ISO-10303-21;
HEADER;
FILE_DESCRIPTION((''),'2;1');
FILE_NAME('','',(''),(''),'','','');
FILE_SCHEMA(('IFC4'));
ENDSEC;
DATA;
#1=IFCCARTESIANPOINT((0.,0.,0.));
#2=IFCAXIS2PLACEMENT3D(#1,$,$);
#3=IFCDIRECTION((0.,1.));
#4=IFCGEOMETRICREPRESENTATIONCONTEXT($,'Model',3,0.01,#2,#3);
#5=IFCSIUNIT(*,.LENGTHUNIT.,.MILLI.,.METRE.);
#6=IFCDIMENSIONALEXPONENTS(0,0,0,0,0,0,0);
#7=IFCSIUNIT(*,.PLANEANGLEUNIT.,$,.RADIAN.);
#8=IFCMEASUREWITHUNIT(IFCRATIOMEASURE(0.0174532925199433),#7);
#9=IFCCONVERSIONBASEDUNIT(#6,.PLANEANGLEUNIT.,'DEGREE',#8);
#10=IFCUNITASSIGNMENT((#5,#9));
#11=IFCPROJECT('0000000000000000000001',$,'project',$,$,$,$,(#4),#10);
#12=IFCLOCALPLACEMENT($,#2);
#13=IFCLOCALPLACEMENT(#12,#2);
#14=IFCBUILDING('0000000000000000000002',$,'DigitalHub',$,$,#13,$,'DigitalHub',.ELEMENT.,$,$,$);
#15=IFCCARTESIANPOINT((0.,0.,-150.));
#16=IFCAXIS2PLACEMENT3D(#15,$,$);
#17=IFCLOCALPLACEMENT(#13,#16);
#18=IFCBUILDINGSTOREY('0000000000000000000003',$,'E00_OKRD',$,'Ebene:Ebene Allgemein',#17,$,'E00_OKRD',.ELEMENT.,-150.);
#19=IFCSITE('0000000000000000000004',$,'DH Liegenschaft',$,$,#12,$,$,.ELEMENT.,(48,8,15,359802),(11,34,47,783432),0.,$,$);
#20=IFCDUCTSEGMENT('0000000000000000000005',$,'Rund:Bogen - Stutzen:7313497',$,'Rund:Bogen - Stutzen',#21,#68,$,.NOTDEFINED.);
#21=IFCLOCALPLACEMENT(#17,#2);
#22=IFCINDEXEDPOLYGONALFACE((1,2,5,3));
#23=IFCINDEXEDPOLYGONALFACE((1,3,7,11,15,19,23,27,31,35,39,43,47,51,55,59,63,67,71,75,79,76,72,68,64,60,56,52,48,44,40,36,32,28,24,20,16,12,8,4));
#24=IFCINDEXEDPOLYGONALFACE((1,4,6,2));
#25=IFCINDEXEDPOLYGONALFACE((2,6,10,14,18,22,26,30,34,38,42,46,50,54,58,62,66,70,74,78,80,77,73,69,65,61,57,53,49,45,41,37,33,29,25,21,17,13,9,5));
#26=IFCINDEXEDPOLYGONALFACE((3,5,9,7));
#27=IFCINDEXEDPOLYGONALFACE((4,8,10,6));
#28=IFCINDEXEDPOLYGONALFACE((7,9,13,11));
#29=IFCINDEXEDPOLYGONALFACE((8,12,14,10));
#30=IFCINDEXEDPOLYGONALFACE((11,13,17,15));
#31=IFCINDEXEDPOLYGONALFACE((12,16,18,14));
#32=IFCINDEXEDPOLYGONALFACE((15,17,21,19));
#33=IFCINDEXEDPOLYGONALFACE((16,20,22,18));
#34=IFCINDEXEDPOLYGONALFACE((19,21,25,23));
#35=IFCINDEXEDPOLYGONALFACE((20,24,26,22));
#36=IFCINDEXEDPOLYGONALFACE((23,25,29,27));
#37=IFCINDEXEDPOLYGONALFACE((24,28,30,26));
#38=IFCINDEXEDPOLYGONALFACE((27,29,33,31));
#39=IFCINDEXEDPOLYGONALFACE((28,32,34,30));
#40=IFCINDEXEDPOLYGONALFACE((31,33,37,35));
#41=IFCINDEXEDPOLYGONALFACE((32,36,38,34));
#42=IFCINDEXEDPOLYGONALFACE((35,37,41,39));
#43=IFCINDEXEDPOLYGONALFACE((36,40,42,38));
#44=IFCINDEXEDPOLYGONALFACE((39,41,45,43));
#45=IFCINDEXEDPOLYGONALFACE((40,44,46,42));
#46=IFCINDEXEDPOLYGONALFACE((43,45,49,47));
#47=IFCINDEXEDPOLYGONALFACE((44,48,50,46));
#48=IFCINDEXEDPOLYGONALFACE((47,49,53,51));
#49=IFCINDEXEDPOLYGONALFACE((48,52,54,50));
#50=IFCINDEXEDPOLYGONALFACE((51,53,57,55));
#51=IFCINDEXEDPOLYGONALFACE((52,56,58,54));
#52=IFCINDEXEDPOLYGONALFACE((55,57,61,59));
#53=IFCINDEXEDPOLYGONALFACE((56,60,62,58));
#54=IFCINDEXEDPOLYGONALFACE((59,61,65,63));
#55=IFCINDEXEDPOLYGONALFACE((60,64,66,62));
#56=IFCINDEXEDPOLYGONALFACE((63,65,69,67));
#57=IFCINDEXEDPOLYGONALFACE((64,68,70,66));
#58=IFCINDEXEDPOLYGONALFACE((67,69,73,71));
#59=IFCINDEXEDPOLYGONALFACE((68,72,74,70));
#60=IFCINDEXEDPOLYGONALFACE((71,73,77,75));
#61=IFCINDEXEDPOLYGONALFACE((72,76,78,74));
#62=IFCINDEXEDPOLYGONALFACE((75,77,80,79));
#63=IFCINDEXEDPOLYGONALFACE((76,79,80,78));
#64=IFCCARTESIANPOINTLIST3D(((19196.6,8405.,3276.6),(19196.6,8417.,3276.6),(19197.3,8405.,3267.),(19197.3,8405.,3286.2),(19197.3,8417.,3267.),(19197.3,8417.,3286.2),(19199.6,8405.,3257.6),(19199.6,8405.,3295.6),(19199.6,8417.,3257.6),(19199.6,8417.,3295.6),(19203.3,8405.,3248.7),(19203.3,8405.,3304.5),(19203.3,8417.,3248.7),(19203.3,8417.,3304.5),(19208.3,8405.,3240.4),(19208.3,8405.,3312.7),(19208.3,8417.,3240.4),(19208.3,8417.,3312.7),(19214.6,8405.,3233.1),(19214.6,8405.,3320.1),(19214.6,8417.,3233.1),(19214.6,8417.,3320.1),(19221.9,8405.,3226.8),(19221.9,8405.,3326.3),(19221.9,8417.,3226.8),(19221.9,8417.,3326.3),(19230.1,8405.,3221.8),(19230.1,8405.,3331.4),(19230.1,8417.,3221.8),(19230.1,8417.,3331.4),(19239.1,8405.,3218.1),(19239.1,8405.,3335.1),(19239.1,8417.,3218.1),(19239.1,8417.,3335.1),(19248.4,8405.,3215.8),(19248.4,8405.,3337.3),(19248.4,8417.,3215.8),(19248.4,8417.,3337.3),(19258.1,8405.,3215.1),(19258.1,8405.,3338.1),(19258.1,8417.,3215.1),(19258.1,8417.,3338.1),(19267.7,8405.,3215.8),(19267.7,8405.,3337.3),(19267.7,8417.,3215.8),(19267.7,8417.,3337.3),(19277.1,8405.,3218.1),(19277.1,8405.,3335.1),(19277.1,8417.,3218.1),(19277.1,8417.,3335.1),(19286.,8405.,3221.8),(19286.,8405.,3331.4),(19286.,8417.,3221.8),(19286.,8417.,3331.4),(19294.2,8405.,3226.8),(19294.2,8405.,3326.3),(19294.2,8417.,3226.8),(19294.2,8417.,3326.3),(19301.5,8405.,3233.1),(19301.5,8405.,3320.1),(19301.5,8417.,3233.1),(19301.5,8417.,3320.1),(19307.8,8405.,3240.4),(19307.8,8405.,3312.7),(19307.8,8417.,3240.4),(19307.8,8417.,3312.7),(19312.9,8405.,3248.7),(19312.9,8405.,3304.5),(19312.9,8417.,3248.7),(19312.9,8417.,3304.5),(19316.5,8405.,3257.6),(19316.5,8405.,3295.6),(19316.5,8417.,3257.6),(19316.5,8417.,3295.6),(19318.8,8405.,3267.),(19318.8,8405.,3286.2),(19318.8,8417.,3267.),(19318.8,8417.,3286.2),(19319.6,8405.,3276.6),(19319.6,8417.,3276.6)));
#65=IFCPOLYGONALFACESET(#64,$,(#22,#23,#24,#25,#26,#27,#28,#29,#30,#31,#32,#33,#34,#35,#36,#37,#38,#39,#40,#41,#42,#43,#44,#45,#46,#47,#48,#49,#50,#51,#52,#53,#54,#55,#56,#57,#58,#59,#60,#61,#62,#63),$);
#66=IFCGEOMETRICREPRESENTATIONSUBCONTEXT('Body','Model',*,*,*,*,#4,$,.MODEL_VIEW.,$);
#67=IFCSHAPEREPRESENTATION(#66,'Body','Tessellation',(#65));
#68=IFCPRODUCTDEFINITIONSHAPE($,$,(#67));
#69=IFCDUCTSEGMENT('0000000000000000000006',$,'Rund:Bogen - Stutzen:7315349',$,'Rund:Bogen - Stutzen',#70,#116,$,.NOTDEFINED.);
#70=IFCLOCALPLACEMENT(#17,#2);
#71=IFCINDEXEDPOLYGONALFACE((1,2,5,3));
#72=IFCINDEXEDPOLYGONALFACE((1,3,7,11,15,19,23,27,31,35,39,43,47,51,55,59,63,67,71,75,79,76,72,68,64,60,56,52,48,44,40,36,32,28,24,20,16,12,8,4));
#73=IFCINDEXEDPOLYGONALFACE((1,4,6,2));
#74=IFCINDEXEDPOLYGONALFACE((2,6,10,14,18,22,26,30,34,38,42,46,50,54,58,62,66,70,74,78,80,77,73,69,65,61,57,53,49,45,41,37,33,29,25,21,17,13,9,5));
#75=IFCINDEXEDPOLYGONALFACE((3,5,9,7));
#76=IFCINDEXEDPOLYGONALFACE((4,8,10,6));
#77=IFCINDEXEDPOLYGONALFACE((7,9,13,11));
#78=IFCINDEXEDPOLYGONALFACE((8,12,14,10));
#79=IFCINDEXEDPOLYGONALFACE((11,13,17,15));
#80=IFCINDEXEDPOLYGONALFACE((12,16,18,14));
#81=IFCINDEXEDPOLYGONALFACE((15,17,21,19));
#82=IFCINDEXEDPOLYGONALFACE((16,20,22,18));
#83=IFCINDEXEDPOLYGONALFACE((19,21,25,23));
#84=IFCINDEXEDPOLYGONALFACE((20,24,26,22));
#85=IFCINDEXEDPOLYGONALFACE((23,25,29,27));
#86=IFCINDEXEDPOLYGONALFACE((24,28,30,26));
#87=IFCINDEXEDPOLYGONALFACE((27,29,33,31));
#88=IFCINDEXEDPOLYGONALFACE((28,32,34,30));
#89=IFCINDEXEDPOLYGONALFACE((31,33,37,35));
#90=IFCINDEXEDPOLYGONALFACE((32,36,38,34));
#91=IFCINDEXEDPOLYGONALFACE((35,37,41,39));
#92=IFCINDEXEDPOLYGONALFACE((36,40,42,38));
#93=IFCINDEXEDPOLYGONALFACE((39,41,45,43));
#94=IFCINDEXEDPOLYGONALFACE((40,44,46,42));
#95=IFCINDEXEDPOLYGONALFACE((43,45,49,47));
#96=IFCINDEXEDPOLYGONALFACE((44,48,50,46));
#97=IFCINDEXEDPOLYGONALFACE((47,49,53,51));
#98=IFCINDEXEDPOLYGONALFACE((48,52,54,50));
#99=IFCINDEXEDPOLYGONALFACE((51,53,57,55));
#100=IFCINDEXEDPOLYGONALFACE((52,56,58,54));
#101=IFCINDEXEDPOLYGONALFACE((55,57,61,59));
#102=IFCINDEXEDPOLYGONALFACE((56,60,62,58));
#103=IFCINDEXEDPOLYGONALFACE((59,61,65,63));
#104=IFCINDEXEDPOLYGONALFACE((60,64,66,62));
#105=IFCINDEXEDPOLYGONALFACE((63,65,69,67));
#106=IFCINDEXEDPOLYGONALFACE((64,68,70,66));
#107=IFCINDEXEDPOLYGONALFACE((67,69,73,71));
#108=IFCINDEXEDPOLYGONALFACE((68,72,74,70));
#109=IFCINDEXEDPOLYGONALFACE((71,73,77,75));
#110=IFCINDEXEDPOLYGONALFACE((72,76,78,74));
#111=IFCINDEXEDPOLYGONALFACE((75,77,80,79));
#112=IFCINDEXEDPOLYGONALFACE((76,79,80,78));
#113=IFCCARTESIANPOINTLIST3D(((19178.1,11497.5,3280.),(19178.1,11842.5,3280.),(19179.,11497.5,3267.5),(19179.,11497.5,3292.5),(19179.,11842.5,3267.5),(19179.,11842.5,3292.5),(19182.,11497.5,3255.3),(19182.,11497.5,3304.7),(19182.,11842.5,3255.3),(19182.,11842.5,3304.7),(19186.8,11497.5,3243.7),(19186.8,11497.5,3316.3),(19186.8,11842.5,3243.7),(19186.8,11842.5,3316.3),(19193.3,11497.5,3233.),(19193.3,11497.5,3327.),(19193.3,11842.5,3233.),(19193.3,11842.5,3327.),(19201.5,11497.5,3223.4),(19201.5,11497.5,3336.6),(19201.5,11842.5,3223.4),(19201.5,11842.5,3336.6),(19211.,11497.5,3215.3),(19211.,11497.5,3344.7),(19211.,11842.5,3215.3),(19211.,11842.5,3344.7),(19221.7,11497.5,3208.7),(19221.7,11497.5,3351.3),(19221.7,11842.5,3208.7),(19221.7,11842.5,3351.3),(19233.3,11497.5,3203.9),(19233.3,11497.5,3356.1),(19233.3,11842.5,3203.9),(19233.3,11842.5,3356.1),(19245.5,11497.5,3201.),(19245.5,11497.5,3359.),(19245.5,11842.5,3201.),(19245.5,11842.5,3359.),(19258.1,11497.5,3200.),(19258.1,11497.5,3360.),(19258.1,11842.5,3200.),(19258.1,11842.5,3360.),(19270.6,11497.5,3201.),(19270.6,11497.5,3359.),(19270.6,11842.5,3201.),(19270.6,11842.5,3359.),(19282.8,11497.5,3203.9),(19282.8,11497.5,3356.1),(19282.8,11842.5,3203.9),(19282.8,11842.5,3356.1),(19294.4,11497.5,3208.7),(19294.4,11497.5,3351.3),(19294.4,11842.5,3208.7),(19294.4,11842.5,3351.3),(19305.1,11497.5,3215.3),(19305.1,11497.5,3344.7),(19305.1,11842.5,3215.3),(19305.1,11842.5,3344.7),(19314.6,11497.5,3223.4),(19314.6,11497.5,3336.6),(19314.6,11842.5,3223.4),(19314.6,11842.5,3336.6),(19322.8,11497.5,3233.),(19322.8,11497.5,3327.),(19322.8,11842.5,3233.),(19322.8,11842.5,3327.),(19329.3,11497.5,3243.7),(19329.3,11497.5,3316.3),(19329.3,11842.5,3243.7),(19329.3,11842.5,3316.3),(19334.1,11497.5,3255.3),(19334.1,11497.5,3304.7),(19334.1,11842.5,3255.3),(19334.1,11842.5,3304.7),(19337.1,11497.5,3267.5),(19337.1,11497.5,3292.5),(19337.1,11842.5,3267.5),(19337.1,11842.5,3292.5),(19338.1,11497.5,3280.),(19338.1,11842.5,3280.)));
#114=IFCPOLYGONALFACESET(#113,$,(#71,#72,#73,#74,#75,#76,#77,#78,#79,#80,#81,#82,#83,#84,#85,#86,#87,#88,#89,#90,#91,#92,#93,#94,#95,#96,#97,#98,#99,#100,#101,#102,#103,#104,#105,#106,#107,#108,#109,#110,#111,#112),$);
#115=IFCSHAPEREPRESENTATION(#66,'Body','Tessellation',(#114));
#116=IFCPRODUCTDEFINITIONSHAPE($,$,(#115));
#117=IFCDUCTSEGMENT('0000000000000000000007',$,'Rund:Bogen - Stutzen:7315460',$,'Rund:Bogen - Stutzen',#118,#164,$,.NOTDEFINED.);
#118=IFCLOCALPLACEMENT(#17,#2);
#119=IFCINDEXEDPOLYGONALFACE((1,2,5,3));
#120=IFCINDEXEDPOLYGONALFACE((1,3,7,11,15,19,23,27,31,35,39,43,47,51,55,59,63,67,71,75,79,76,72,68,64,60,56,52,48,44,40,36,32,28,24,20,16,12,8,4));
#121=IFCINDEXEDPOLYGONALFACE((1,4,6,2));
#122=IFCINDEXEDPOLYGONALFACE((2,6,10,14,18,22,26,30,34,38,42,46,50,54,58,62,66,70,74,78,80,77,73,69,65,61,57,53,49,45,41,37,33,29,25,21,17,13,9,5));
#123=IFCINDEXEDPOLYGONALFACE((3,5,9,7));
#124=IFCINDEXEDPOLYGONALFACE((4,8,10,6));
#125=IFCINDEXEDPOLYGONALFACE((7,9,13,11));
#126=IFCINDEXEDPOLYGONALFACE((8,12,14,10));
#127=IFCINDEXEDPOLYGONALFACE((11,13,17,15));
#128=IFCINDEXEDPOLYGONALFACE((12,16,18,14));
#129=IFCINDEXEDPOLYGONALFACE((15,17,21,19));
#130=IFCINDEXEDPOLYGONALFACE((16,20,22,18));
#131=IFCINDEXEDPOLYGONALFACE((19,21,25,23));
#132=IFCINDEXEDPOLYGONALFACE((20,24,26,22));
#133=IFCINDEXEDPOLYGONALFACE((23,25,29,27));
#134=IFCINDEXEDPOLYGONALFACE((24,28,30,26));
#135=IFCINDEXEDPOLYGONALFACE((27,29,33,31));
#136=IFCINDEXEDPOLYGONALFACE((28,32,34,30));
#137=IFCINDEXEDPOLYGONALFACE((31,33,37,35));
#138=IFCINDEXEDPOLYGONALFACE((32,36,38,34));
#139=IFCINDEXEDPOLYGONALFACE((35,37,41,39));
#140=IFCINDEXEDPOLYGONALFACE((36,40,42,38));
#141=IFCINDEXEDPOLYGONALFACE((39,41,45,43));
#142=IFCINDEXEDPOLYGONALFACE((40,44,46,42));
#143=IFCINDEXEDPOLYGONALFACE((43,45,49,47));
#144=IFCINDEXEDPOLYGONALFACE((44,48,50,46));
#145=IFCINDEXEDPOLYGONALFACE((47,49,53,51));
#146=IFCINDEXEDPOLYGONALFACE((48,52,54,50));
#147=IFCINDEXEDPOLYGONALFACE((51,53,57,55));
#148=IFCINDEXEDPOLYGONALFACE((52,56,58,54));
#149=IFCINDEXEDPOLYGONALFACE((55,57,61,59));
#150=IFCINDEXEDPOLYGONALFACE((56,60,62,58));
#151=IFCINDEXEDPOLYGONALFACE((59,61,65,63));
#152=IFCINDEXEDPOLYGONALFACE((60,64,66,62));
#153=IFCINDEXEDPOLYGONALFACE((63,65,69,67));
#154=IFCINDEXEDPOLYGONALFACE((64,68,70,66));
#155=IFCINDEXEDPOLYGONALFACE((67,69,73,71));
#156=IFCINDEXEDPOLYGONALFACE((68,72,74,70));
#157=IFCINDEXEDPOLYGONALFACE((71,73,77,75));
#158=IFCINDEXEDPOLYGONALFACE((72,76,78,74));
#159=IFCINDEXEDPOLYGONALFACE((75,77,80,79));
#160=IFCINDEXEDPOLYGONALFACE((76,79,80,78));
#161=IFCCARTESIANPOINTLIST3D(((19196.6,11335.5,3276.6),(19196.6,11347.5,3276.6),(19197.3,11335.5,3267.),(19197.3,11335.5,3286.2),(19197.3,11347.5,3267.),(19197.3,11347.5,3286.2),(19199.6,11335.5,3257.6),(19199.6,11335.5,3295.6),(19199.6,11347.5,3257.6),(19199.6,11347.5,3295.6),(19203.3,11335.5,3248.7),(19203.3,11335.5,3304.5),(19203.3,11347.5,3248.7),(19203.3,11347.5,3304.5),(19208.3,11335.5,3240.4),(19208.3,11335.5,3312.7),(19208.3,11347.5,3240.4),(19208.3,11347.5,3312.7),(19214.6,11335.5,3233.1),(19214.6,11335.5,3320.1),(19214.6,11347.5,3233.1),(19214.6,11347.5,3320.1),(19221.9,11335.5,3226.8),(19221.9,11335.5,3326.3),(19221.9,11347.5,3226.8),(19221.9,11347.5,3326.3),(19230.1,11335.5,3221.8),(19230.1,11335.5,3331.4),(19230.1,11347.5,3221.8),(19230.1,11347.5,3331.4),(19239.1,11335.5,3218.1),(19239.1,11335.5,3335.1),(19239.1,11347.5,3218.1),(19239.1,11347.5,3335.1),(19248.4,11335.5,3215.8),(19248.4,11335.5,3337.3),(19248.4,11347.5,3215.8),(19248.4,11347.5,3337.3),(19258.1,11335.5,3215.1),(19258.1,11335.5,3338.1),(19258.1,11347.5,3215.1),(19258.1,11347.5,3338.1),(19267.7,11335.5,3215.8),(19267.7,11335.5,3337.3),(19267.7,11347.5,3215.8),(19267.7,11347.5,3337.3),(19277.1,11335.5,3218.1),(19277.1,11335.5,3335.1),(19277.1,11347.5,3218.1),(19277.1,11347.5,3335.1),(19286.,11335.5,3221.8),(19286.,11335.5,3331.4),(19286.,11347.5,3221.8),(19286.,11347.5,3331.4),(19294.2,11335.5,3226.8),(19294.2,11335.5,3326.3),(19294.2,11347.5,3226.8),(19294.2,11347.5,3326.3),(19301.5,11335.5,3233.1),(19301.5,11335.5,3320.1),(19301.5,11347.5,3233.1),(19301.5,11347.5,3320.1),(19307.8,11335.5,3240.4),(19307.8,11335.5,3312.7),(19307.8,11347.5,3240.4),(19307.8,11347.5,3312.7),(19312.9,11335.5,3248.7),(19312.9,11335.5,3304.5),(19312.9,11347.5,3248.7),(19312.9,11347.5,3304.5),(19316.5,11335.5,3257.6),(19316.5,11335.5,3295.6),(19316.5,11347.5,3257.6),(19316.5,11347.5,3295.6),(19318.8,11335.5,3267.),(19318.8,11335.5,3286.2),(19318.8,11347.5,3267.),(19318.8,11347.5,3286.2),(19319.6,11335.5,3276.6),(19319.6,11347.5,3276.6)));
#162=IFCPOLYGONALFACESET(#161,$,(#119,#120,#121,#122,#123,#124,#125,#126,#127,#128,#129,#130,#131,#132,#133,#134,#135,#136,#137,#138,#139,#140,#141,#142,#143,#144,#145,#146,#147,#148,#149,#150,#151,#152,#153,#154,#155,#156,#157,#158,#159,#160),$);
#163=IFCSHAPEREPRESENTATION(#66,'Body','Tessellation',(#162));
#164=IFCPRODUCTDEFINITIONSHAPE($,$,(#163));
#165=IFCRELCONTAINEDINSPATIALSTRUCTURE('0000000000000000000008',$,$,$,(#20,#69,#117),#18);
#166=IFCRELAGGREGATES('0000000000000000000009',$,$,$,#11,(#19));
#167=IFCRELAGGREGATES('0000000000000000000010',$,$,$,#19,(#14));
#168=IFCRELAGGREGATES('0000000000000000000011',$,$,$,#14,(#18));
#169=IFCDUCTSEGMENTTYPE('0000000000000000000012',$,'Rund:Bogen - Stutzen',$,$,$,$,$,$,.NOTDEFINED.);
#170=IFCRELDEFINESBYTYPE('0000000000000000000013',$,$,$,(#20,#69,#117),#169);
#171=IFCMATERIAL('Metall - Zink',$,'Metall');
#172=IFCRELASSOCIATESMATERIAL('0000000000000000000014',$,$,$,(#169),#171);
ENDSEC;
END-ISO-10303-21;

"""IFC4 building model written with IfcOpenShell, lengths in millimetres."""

from ifc_helpers import new_model, entity, si_unit, converted_unit, direction, frame, origin, place, context, subcontext, project, spatial, indexed_curve, outline, extrude, material, type_object, element, save


model = new_model("IFC4")

# Units and contexts
model_context = context("Model", 3, precision=0.01, world=origin(), true_north=direction((0.0, 1.0)))
body_context = subcontext(model_context, "Body", "Model", "MODEL_VIEW")
ifc_project = project(units=[si_unit("LENGTHUNIT", "METRE", prefix="MILLI"), converted_unit("PLANEANGLEUNIT", "DEGREE", entity("IfcRatioMeasure", 0.0174532925199433), si_unit("PLANEANGLEUNIT", "RADIAN"), dimensions=[0, 0, 0, 0, 0, 0, 0])], contexts=[model_context])

# Site, building, storey
site_placement = place(None, origin())
site = spatial("IfcSite", under=ifc_project, at=site_placement, Name="DH Liegenschaft", CompositionType="ELEMENT", RefLatitude=(48, 8, 15, 359802), RefLongitude=(11, 34, 47, 783432), RefElevation=0.0)
building_placement = place(site_placement, origin())
building = spatial("IfcBuilding", under=site, at=building_placement, Name="DigitalHub", LongName="DigitalHub", CompositionType="ELEMENT")
storey_placement = place(building_placement, frame((0.0, 0.0, -150.0)))
storey = spatial("IfcBuildingStorey", under=building, at=storey_placement, Name="E00_OKRD", ObjectType="Ebene:Ebene Allgemein", LongName="E00_OKRD", CompositionType="ELEMENT", Elevation=-150.0)

# Duct segments
ifc_material_1 = material(Name="Metall - Zink", Category="Metall")
duct_segment_type_1 = type_object("IfcDuctSegmentType", Name="Rund:Bogen - Stutzen", PredefinedType="NOTDEFINED", material=ifc_material_1)
duct_segment_1_placement = place(storey_placement, frame((19195.0, 8405.0, 3213.5)))
element("IfcDuctSegment", 1, at=duct_segment_1_placement, inside=storey, type_object=duct_segment_type_1, Name="Rund:Bogen - Stutzen:7313497", ObjectType="Rund:Bogen - Stutzen", PredefinedType="NOTDEFINED", context=body_context, shape_type="SweptSolid", body=[
    extrude(outline(indexed_curve([(61.5, 0.0), (60.7, 9.6), (58.5, 19.0), (54.8, 27.9), (49.8, 36.1), (43.5, 43.5), (36.1, 49.8), (27.9, 54.8), (19.0, 58.5), (9.6, 60.7), (0.0, 61.5), (-9.6, 60.7), (-19.0, 58.5), (-27.9, 54.8), (-36.1, 49.8), (-43.5, 43.5), (-49.8, 36.1), (-54.8, 27.9), (-58.5, 19.0), (-60.7, 9.6), (-61.5, 0.0), (-60.7, -9.6), (-58.5, -19.0), (-54.8, -27.9), (-49.8, -36.1), (-43.5, -43.5), (-36.1, -49.8), (-27.9, -54.8), (-19.0, -58.5), (-9.6, -60.7), (0.0, -61.5), (9.6, -60.7), (19.0, -58.5), (27.9, -54.8), (36.1, -49.8), (43.5, -43.5), (49.8, -36.1), (54.8, -27.9), (58.5, -19.0), (60.7, -9.6), (61.5, 0.0)], self_intersect=False)), frame((63.1, 0.0, 63.1), z_axis=(0.0, 1.0, 0.0), x_axis=(1.0, 0.0, 0.0)), (0.0, 0.0, 1.0), 12.0),
])
duct_segment_2_placement = place(storey_placement, frame((19176.5, 11497.5, 3198.4)))
element("IfcDuctSegment", 2, at=duct_segment_2_placement, inside=storey, type_object=duct_segment_type_1, Name="Rund:Bogen - Stutzen:7315349", ObjectType="Rund:Bogen - Stutzen", PredefinedType="NOTDEFINED", context=body_context, shape_type="SweptSolid", body=[
    extrude(outline(indexed_curve([(80.0, 0.0), (79.0, 12.5), (76.1, 24.7), (71.3, 36.3), (64.7, 47.0), (56.6, 56.6), (47.0, 64.7), (36.3, 71.3), (24.7, 76.1), (12.5, 79.0), (0.0, 80.0), (-12.5, 79.0), (-24.7, 76.1), (-36.3, 71.3), (-47.0, 64.7), (-56.6, 56.6), (-64.7, 47.0), (-71.3, 36.3), (-76.1, 24.7), (-79.0, 12.5), (-80.0, 0.0), (-79.0, -12.5), (-76.1, -24.7), (-71.3, -36.3), (-64.7, -47.0), (-56.6, -56.6), (-47.0, -64.7), (-36.3, -71.3), (-24.7, -76.1), (-12.5, -79.0), (0.0, -80.0), (12.5, -79.0), (24.7, -76.1), (36.3, -71.3), (47.0, -64.7), (56.6, -56.6), (64.7, -47.0), (71.3, -36.3), (76.1, -24.7), (79.0, -12.5), (80.0, 0.0)], self_intersect=False)), frame((81.6, 0.0, 81.6), z_axis=(0.0, 1.0, 0.0), x_axis=(-1.0, 0.0, 0.0)), (0.0, 0.0, 1.0), 345.0),
])
duct_segment_3_placement = place(storey_placement, frame((19195.0, 11335.5, 3213.5)))
element("IfcDuctSegment", 3, at=duct_segment_3_placement, inside=storey, type_object=duct_segment_type_1, Name="Rund:Bogen - Stutzen:7315460", ObjectType="Rund:Bogen - Stutzen", PredefinedType="NOTDEFINED", context=body_context, shape_type="SweptSolid", body=[
    extrude(outline(indexed_curve([(61.5, 0.0), (60.7, 9.6), (58.5, 19.0), (54.8, 27.9), (49.8, 36.1), (43.5, 43.5), (36.1, 49.8), (27.9, 54.8), (19.0, 58.5), (9.6, 60.7), (0.0, 61.5), (-9.6, 60.7), (-19.0, 58.5), (-27.9, 54.8), (-36.1, 49.8), (-43.5, 43.5), (-49.8, 36.1), (-54.8, 27.9), (-58.5, 19.0), (-60.7, 9.6), (-61.5, 0.0), (-60.7, -9.6), (-58.5, -19.0), (-54.8, -27.9), (-49.8, -36.1), (-43.5, -43.5), (-36.1, -49.8), (-27.9, -54.8), (-19.0, -58.5), (-9.6, -60.7), (0.0, -61.5), (9.6, -60.7), (19.0, -58.5), (27.9, -54.8), (36.1, -49.8), (43.5, -43.5), (49.8, -36.1), (54.8, -27.9), (58.5, -19.0), (60.7, -9.6), (61.5, 0.0)], self_intersect=False)), frame((63.1, 0.0, 63.1), z_axis=(0.0, 1.0, 0.0), x_axis=(-1.0, 0.0, 0.0)), (0.0, 0.0, 1.0), 12.0),
])

save(model, "model.ifc")
